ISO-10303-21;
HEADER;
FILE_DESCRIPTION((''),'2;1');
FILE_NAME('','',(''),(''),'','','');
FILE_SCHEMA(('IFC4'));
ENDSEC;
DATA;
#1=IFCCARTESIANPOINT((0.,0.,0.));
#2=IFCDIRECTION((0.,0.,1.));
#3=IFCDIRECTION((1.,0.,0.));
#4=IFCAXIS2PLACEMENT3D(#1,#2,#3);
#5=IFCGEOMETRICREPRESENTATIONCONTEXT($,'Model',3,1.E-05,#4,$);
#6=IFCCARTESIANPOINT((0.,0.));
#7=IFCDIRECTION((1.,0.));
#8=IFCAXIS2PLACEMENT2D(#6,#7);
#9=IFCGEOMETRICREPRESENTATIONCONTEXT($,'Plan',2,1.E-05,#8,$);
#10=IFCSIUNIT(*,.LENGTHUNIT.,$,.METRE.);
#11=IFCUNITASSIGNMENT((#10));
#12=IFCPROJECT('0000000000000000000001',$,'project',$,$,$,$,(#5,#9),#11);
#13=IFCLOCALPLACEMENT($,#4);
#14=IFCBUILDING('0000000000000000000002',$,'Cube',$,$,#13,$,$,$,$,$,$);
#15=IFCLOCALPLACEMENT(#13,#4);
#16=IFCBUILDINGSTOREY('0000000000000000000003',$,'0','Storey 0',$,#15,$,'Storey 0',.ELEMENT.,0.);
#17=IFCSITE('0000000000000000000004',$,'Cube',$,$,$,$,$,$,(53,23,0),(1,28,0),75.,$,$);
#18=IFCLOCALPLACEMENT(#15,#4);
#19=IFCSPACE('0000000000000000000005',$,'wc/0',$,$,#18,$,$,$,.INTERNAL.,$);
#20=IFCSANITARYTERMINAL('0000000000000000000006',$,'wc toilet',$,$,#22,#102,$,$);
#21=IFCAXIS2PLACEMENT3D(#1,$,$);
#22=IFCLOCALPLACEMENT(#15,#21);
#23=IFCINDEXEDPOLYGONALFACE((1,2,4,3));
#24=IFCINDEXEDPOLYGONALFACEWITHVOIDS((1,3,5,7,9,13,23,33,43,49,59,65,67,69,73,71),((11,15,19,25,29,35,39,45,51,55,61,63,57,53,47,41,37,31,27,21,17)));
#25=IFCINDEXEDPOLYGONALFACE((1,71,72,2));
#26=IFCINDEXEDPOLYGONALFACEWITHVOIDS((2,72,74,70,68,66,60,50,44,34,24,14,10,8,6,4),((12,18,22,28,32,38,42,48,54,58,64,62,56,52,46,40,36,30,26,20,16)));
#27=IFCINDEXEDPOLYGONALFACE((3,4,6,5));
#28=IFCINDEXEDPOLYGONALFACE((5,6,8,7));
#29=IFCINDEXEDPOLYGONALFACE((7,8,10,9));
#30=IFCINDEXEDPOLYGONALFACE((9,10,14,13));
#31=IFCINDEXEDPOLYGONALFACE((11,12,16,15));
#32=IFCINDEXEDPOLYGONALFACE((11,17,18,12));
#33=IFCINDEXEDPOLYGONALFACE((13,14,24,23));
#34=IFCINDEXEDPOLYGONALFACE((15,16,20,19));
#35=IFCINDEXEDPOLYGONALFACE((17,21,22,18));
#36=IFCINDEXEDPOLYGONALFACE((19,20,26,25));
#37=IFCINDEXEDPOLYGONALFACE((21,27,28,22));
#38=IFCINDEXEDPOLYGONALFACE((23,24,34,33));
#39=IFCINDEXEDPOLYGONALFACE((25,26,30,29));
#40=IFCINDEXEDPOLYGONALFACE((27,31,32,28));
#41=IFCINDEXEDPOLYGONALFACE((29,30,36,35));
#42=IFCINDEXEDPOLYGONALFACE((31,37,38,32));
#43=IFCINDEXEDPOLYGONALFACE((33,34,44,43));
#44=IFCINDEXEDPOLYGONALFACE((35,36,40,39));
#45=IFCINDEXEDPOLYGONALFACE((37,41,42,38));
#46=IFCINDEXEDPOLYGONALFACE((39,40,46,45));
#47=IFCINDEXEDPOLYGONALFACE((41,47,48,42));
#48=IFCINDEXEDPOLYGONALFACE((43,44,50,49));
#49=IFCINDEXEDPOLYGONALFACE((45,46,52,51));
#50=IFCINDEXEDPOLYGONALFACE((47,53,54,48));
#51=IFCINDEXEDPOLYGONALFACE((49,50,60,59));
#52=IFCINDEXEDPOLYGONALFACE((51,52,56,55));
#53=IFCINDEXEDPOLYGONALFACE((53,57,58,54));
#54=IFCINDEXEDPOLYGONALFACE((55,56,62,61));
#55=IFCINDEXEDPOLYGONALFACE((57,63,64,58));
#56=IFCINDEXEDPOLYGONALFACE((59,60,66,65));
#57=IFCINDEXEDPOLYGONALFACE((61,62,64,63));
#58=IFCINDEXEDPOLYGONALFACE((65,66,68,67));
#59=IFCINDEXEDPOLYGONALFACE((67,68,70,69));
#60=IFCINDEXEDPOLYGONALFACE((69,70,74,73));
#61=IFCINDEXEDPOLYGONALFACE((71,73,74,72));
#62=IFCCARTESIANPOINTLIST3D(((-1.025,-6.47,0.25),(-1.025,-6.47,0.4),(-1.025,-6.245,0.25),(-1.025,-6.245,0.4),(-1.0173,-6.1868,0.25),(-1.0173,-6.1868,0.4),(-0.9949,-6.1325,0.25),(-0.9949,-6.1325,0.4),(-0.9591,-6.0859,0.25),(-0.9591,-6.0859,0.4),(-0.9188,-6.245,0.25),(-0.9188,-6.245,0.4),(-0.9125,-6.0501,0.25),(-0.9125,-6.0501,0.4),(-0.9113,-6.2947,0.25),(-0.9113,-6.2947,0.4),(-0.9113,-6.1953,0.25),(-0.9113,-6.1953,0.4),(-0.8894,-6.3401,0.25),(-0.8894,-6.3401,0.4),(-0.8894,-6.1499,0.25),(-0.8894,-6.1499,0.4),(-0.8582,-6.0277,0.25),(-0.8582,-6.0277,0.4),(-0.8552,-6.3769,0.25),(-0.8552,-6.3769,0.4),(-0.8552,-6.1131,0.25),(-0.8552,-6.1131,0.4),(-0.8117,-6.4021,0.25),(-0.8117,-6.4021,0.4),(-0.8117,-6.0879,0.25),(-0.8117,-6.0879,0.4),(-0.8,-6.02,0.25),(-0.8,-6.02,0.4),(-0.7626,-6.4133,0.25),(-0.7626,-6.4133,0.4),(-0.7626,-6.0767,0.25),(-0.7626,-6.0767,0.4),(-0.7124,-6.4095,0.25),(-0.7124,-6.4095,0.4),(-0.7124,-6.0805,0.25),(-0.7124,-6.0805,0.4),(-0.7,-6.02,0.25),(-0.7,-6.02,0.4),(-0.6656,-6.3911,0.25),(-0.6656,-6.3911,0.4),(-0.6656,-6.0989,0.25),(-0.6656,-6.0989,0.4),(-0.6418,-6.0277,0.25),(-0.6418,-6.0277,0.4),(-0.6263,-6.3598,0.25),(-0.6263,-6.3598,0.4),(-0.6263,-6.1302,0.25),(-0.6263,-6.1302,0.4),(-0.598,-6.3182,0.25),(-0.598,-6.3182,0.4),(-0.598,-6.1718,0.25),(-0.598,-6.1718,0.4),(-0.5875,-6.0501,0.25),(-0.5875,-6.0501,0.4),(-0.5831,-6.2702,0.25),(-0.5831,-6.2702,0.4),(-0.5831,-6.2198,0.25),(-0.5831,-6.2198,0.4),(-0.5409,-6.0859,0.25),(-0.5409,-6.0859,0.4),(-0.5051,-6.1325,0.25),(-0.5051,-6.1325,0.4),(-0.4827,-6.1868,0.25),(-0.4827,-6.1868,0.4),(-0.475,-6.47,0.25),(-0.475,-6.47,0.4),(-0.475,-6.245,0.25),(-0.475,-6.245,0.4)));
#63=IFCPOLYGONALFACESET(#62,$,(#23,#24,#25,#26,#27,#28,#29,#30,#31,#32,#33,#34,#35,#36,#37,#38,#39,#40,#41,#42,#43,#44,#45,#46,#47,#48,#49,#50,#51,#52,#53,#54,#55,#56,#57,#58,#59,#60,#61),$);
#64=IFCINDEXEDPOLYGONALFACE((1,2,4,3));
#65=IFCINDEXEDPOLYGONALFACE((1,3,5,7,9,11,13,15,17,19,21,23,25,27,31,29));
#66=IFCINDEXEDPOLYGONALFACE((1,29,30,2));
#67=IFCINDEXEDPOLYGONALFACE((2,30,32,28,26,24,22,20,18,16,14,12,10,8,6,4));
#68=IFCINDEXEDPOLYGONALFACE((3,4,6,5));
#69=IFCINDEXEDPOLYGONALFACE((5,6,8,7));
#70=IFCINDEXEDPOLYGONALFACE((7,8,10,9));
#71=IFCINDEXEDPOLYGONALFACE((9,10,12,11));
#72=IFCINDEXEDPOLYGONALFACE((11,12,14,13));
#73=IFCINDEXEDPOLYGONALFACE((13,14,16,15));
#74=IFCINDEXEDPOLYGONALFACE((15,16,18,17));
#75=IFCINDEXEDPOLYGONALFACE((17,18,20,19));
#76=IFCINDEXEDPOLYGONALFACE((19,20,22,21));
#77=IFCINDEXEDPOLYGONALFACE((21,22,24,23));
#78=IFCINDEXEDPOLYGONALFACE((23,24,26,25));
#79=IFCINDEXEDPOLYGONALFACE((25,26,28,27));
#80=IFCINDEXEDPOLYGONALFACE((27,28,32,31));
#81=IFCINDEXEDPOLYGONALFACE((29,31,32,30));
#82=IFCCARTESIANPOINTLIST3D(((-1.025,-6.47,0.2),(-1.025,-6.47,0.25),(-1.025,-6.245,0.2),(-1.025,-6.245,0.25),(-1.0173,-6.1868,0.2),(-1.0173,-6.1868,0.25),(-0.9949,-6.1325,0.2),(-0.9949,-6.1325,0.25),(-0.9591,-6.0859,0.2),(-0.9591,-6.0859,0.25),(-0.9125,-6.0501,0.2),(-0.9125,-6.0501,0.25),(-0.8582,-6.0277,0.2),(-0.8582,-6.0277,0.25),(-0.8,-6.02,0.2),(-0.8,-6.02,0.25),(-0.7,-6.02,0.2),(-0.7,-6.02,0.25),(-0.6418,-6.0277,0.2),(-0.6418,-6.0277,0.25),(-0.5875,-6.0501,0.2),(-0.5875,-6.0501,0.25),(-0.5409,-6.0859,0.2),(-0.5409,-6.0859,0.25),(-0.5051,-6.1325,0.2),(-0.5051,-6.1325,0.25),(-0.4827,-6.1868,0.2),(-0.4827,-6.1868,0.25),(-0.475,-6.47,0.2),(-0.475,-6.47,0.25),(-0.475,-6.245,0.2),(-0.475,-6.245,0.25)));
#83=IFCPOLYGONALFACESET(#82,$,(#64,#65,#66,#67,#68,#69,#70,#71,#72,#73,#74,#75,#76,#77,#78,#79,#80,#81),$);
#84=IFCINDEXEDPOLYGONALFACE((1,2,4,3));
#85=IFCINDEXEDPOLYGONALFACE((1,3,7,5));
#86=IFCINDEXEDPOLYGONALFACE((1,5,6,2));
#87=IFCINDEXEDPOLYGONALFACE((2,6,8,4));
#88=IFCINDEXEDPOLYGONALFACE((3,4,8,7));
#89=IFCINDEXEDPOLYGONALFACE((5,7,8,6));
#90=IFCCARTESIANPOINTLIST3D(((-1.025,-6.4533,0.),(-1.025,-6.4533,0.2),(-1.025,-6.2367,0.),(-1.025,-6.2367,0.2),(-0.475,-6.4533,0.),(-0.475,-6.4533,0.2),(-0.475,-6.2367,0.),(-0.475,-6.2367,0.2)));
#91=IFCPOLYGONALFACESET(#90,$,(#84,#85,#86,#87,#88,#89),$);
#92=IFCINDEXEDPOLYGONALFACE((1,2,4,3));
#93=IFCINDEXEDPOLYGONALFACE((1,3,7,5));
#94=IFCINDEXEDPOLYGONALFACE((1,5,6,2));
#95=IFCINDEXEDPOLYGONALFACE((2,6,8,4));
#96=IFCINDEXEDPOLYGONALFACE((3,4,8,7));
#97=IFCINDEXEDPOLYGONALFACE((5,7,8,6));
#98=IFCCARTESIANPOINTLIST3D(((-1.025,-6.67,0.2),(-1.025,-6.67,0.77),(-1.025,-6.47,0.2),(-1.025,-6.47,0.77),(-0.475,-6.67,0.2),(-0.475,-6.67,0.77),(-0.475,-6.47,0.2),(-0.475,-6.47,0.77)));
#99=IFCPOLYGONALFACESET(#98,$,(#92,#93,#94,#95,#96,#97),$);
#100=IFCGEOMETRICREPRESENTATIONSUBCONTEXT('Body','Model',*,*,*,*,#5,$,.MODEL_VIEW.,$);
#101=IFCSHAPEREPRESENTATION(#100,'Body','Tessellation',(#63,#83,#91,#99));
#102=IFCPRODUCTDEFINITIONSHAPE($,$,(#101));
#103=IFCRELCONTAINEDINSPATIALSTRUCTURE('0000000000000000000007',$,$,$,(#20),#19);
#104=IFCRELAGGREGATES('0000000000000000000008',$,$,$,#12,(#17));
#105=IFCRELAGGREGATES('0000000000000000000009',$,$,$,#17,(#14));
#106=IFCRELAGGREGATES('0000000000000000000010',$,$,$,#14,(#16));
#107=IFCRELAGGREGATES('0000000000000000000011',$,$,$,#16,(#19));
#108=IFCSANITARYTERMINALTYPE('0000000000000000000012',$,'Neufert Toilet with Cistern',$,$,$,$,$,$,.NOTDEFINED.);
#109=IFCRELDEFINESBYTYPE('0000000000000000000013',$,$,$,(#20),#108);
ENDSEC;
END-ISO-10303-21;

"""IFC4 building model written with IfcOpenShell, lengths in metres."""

from ifc_helpers import new_model, entity, si_unit, frame, frame_2d, origin_with_axes, origin_2d_with_axis, place, context, subcontext, project, spatial, line, arc, indexed_curve, circle_curve, outline, extrude, shape, source, transform, mapped, type_object, type_shapes, element, save


model = new_model("IFC4")

# Units and contexts
model_context = context("Model", 3, precision=1e-05, world=origin_with_axes())
plan_context = context("Plan", 2, precision=1e-05, world=origin_2d_with_axis())
body_context_1 = subcontext(model_context, "Body", "Model", "MODEL_VIEW")
body_context_2 = subcontext(plan_context, "Body", "Plan", "PLAN_VIEW")
ifc_project = project(units=[si_unit("LENGTHUNIT", "METRE")], contexts=[model_context, plan_context])

# Site, building, storey
site = spatial("IfcSite", under=ifc_project, Name="Cube", RefLatitude=(53, 23, 0), RefLongitude=(1, 28, 0), RefElevation=75.0)
building_placement = place(None, origin_with_axes())
building = spatial("IfcBuilding", under=site, at=building_placement, Name="Cube")
storey_placement = place(building_placement, origin_with_axes())
storey = spatial("IfcBuildingStorey", under=building, at=storey_placement, Name="0", Description="Storey 0", LongName="Storey 0", CompositionType="ELEMENT", Elevation=0.0)

# Shared definitions
space_1_placement = place(storey_placement, origin_with_axes())
space_1 = spatial("IfcSpace", under=storey, at=space_1_placement, Name="wc/0", PredefinedType="INTERNAL")

# Sanitary terminal
sanitary_terminal_type_1 = type_object("IfcSanitaryTerminalType", Name="Neufert Toilet with Cistern", PredefinedType="NOTDEFINED")
shared_shape_1 = source(origin_with_axes(), body_context_1, "Body", "SweptSolid", [
    extrude(outline(indexed_curve([(-0.275, -0.2), (0.275, -0.2), (0.275, -0.425), (0.2091, -0.5841), (0.05, -0.65), (-0.05, -0.65), (-0.2091, -0.5841), (-0.275, -0.425)], segments=[line(1, 2), line(2, 3), arc(3, 4, 5), line(5, 6), arc(6, 7, 8), line(8, 1)]), holes=[circle_curve(frame_2d((0.0, -0.425)), 0.1688)]), frame((0.0, 0.0, 0.25), z_axis=(0.0, 0.0, 1.0), x_axis=(1.0, 0.0, 0.0)), (0.0, 0.0, 1.0), 0.15),
    extrude(outline(indexed_curve([(-0.275, -0.2), (0.275, -0.2), (0.275, -0.425), (0.2091, -0.5841), (0.05, -0.65), (-0.05, -0.65), (-0.2091, -0.5841), (-0.275, -0.425)], segments=[line(1, 2), line(2, 3), arc(3, 4, 5), line(5, 6), arc(6, 7, 8), line(8, 1)])), frame((0.0, 0.0, 0.2), z_axis=(0.0, 0.0, 1.0), x_axis=(1.0, 0.0, 0.0)), (0.0, 0.0, 1.0), 0.05),
    extrude(outline(indexed_curve([(-0.275, -0.2167), (0.275, -0.2167), (0.275, -0.4333), (-0.275, -0.4333)], segments=[line(1, 2, 3, 4, 1)])), origin_with_axes(), (0.0, 0.0, 1.0), 0.2),
    extrude(outline(indexed_curve([(-0.275, 0.0), (0.275, 0.0), (0.275, -0.2), (-0.275, -0.2)], segments=[line(1, 2, 3, 4, 1)])), frame((0.0, 0.0, 0.2), z_axis=(0.0, 0.0, 1.0), x_axis=(1.0, 0.0, 0.0)), (0.0, 0.0, 1.0), 0.57),
])
shared_shape_2 = source(origin_with_axes(), body_context_2, "Body", "Curve2D", [
    entity("IfcIndexedPolyCurve", entity("IfcCartesianPointList2D", [[-0.275, 0.0], [0.275, 0.0], [0.275, -0.2], [-0.275, -0.2]]), [entity("IfcLineIndex", [1, 2, 3, 4, 1])]),
    entity("IfcIndexedPolyCurve", entity("IfcCartesianPointList2D", [[0.165, -0.2], [0.1925, -0.335]])),
    entity("IfcTrimmedCurve", entity("IfcEllipse", entity("IfcAxis2Placement2D", entity("IfcCartesianPoint", [0.0, -0.335]), entity("IfcDirection", [1.0, 0.0])), 0.1925, 0.315), [entity("IfcCartesianPoint", [-0.1925, -0.335])], [entity("IfcCartesianPoint", [0.1925, -0.335])], True, "CARTESIAN"),
    entity("IfcIndexedPolyCurve", entity("IfcCartesianPointList2D", [[-0.165, -0.2], [-0.1925, -0.335]])),
    entity("IfcEllipse", entity("IfcAxis2Placement2D", entity("IfcCartesianPoint", [0.0, -0.452]), entity("IfcDirection", [1.0, 0.0])), 0.1313, 0.1575),
    entity("IfcIndexedPolyCurve", entity("IfcCartesianPointList2D", [[-0.0344, -0.452], [-0.0344, -0.4295], [0.0344, -0.4295], [0.0344, -0.452]])),
    entity("IfcTrimmedCurve", entity("IfcEllipse", entity("IfcAxis2Placement2D", entity("IfcCartesianPoint", [0.0, -0.452]), entity("IfcDirection", [1.0, 0.0])), 0.0344, 0.0225), [entity("IfcCartesianPoint", [-0.0344, -0.452])], [entity("IfcCartesianPoint", [0.0344, -0.452])], True, "CARTESIAN"),
])
type_shapes(sanitary_terminal_type_1, [shared_shape_1, shared_shape_2])
sanitary_terminal_1_placement = place(space_1_placement, frame((-0.75, -6.67, 0.0), z_axis=(0.0, 0.0, 1.0), x_axis=(-1.0, 0.0, 0.0)))
element("IfcSanitaryTerminal", 1, at=sanitary_terminal_1_placement, inside=space_1, type_object=sanitary_terminal_type_1, Name="wc toilet", shapes=[
    shape(body_context_1, "Body", "MappedRepresentation", [mapped(shared_shape_1, transform((0.0, 0.0, 0.0), x_axis=(1.0, 0.0, 0.0), y_axis=(0.0, 1.0, 0.0), z_axis=(0.0, 0.0, 1.0), scale=1.0))]),
    shape(body_context_2, "Body", "MappedRepresentation", [mapped(shared_shape_2, transform((0.0, 0.0, 0.0), x_axis=(1.0, 0.0, 0.0), y_axis=(0.0, 1.0, 0.0), z_axis=(0.0, 0.0, 1.0), scale=1.0))]),
])

save(model, "model.ifc")
